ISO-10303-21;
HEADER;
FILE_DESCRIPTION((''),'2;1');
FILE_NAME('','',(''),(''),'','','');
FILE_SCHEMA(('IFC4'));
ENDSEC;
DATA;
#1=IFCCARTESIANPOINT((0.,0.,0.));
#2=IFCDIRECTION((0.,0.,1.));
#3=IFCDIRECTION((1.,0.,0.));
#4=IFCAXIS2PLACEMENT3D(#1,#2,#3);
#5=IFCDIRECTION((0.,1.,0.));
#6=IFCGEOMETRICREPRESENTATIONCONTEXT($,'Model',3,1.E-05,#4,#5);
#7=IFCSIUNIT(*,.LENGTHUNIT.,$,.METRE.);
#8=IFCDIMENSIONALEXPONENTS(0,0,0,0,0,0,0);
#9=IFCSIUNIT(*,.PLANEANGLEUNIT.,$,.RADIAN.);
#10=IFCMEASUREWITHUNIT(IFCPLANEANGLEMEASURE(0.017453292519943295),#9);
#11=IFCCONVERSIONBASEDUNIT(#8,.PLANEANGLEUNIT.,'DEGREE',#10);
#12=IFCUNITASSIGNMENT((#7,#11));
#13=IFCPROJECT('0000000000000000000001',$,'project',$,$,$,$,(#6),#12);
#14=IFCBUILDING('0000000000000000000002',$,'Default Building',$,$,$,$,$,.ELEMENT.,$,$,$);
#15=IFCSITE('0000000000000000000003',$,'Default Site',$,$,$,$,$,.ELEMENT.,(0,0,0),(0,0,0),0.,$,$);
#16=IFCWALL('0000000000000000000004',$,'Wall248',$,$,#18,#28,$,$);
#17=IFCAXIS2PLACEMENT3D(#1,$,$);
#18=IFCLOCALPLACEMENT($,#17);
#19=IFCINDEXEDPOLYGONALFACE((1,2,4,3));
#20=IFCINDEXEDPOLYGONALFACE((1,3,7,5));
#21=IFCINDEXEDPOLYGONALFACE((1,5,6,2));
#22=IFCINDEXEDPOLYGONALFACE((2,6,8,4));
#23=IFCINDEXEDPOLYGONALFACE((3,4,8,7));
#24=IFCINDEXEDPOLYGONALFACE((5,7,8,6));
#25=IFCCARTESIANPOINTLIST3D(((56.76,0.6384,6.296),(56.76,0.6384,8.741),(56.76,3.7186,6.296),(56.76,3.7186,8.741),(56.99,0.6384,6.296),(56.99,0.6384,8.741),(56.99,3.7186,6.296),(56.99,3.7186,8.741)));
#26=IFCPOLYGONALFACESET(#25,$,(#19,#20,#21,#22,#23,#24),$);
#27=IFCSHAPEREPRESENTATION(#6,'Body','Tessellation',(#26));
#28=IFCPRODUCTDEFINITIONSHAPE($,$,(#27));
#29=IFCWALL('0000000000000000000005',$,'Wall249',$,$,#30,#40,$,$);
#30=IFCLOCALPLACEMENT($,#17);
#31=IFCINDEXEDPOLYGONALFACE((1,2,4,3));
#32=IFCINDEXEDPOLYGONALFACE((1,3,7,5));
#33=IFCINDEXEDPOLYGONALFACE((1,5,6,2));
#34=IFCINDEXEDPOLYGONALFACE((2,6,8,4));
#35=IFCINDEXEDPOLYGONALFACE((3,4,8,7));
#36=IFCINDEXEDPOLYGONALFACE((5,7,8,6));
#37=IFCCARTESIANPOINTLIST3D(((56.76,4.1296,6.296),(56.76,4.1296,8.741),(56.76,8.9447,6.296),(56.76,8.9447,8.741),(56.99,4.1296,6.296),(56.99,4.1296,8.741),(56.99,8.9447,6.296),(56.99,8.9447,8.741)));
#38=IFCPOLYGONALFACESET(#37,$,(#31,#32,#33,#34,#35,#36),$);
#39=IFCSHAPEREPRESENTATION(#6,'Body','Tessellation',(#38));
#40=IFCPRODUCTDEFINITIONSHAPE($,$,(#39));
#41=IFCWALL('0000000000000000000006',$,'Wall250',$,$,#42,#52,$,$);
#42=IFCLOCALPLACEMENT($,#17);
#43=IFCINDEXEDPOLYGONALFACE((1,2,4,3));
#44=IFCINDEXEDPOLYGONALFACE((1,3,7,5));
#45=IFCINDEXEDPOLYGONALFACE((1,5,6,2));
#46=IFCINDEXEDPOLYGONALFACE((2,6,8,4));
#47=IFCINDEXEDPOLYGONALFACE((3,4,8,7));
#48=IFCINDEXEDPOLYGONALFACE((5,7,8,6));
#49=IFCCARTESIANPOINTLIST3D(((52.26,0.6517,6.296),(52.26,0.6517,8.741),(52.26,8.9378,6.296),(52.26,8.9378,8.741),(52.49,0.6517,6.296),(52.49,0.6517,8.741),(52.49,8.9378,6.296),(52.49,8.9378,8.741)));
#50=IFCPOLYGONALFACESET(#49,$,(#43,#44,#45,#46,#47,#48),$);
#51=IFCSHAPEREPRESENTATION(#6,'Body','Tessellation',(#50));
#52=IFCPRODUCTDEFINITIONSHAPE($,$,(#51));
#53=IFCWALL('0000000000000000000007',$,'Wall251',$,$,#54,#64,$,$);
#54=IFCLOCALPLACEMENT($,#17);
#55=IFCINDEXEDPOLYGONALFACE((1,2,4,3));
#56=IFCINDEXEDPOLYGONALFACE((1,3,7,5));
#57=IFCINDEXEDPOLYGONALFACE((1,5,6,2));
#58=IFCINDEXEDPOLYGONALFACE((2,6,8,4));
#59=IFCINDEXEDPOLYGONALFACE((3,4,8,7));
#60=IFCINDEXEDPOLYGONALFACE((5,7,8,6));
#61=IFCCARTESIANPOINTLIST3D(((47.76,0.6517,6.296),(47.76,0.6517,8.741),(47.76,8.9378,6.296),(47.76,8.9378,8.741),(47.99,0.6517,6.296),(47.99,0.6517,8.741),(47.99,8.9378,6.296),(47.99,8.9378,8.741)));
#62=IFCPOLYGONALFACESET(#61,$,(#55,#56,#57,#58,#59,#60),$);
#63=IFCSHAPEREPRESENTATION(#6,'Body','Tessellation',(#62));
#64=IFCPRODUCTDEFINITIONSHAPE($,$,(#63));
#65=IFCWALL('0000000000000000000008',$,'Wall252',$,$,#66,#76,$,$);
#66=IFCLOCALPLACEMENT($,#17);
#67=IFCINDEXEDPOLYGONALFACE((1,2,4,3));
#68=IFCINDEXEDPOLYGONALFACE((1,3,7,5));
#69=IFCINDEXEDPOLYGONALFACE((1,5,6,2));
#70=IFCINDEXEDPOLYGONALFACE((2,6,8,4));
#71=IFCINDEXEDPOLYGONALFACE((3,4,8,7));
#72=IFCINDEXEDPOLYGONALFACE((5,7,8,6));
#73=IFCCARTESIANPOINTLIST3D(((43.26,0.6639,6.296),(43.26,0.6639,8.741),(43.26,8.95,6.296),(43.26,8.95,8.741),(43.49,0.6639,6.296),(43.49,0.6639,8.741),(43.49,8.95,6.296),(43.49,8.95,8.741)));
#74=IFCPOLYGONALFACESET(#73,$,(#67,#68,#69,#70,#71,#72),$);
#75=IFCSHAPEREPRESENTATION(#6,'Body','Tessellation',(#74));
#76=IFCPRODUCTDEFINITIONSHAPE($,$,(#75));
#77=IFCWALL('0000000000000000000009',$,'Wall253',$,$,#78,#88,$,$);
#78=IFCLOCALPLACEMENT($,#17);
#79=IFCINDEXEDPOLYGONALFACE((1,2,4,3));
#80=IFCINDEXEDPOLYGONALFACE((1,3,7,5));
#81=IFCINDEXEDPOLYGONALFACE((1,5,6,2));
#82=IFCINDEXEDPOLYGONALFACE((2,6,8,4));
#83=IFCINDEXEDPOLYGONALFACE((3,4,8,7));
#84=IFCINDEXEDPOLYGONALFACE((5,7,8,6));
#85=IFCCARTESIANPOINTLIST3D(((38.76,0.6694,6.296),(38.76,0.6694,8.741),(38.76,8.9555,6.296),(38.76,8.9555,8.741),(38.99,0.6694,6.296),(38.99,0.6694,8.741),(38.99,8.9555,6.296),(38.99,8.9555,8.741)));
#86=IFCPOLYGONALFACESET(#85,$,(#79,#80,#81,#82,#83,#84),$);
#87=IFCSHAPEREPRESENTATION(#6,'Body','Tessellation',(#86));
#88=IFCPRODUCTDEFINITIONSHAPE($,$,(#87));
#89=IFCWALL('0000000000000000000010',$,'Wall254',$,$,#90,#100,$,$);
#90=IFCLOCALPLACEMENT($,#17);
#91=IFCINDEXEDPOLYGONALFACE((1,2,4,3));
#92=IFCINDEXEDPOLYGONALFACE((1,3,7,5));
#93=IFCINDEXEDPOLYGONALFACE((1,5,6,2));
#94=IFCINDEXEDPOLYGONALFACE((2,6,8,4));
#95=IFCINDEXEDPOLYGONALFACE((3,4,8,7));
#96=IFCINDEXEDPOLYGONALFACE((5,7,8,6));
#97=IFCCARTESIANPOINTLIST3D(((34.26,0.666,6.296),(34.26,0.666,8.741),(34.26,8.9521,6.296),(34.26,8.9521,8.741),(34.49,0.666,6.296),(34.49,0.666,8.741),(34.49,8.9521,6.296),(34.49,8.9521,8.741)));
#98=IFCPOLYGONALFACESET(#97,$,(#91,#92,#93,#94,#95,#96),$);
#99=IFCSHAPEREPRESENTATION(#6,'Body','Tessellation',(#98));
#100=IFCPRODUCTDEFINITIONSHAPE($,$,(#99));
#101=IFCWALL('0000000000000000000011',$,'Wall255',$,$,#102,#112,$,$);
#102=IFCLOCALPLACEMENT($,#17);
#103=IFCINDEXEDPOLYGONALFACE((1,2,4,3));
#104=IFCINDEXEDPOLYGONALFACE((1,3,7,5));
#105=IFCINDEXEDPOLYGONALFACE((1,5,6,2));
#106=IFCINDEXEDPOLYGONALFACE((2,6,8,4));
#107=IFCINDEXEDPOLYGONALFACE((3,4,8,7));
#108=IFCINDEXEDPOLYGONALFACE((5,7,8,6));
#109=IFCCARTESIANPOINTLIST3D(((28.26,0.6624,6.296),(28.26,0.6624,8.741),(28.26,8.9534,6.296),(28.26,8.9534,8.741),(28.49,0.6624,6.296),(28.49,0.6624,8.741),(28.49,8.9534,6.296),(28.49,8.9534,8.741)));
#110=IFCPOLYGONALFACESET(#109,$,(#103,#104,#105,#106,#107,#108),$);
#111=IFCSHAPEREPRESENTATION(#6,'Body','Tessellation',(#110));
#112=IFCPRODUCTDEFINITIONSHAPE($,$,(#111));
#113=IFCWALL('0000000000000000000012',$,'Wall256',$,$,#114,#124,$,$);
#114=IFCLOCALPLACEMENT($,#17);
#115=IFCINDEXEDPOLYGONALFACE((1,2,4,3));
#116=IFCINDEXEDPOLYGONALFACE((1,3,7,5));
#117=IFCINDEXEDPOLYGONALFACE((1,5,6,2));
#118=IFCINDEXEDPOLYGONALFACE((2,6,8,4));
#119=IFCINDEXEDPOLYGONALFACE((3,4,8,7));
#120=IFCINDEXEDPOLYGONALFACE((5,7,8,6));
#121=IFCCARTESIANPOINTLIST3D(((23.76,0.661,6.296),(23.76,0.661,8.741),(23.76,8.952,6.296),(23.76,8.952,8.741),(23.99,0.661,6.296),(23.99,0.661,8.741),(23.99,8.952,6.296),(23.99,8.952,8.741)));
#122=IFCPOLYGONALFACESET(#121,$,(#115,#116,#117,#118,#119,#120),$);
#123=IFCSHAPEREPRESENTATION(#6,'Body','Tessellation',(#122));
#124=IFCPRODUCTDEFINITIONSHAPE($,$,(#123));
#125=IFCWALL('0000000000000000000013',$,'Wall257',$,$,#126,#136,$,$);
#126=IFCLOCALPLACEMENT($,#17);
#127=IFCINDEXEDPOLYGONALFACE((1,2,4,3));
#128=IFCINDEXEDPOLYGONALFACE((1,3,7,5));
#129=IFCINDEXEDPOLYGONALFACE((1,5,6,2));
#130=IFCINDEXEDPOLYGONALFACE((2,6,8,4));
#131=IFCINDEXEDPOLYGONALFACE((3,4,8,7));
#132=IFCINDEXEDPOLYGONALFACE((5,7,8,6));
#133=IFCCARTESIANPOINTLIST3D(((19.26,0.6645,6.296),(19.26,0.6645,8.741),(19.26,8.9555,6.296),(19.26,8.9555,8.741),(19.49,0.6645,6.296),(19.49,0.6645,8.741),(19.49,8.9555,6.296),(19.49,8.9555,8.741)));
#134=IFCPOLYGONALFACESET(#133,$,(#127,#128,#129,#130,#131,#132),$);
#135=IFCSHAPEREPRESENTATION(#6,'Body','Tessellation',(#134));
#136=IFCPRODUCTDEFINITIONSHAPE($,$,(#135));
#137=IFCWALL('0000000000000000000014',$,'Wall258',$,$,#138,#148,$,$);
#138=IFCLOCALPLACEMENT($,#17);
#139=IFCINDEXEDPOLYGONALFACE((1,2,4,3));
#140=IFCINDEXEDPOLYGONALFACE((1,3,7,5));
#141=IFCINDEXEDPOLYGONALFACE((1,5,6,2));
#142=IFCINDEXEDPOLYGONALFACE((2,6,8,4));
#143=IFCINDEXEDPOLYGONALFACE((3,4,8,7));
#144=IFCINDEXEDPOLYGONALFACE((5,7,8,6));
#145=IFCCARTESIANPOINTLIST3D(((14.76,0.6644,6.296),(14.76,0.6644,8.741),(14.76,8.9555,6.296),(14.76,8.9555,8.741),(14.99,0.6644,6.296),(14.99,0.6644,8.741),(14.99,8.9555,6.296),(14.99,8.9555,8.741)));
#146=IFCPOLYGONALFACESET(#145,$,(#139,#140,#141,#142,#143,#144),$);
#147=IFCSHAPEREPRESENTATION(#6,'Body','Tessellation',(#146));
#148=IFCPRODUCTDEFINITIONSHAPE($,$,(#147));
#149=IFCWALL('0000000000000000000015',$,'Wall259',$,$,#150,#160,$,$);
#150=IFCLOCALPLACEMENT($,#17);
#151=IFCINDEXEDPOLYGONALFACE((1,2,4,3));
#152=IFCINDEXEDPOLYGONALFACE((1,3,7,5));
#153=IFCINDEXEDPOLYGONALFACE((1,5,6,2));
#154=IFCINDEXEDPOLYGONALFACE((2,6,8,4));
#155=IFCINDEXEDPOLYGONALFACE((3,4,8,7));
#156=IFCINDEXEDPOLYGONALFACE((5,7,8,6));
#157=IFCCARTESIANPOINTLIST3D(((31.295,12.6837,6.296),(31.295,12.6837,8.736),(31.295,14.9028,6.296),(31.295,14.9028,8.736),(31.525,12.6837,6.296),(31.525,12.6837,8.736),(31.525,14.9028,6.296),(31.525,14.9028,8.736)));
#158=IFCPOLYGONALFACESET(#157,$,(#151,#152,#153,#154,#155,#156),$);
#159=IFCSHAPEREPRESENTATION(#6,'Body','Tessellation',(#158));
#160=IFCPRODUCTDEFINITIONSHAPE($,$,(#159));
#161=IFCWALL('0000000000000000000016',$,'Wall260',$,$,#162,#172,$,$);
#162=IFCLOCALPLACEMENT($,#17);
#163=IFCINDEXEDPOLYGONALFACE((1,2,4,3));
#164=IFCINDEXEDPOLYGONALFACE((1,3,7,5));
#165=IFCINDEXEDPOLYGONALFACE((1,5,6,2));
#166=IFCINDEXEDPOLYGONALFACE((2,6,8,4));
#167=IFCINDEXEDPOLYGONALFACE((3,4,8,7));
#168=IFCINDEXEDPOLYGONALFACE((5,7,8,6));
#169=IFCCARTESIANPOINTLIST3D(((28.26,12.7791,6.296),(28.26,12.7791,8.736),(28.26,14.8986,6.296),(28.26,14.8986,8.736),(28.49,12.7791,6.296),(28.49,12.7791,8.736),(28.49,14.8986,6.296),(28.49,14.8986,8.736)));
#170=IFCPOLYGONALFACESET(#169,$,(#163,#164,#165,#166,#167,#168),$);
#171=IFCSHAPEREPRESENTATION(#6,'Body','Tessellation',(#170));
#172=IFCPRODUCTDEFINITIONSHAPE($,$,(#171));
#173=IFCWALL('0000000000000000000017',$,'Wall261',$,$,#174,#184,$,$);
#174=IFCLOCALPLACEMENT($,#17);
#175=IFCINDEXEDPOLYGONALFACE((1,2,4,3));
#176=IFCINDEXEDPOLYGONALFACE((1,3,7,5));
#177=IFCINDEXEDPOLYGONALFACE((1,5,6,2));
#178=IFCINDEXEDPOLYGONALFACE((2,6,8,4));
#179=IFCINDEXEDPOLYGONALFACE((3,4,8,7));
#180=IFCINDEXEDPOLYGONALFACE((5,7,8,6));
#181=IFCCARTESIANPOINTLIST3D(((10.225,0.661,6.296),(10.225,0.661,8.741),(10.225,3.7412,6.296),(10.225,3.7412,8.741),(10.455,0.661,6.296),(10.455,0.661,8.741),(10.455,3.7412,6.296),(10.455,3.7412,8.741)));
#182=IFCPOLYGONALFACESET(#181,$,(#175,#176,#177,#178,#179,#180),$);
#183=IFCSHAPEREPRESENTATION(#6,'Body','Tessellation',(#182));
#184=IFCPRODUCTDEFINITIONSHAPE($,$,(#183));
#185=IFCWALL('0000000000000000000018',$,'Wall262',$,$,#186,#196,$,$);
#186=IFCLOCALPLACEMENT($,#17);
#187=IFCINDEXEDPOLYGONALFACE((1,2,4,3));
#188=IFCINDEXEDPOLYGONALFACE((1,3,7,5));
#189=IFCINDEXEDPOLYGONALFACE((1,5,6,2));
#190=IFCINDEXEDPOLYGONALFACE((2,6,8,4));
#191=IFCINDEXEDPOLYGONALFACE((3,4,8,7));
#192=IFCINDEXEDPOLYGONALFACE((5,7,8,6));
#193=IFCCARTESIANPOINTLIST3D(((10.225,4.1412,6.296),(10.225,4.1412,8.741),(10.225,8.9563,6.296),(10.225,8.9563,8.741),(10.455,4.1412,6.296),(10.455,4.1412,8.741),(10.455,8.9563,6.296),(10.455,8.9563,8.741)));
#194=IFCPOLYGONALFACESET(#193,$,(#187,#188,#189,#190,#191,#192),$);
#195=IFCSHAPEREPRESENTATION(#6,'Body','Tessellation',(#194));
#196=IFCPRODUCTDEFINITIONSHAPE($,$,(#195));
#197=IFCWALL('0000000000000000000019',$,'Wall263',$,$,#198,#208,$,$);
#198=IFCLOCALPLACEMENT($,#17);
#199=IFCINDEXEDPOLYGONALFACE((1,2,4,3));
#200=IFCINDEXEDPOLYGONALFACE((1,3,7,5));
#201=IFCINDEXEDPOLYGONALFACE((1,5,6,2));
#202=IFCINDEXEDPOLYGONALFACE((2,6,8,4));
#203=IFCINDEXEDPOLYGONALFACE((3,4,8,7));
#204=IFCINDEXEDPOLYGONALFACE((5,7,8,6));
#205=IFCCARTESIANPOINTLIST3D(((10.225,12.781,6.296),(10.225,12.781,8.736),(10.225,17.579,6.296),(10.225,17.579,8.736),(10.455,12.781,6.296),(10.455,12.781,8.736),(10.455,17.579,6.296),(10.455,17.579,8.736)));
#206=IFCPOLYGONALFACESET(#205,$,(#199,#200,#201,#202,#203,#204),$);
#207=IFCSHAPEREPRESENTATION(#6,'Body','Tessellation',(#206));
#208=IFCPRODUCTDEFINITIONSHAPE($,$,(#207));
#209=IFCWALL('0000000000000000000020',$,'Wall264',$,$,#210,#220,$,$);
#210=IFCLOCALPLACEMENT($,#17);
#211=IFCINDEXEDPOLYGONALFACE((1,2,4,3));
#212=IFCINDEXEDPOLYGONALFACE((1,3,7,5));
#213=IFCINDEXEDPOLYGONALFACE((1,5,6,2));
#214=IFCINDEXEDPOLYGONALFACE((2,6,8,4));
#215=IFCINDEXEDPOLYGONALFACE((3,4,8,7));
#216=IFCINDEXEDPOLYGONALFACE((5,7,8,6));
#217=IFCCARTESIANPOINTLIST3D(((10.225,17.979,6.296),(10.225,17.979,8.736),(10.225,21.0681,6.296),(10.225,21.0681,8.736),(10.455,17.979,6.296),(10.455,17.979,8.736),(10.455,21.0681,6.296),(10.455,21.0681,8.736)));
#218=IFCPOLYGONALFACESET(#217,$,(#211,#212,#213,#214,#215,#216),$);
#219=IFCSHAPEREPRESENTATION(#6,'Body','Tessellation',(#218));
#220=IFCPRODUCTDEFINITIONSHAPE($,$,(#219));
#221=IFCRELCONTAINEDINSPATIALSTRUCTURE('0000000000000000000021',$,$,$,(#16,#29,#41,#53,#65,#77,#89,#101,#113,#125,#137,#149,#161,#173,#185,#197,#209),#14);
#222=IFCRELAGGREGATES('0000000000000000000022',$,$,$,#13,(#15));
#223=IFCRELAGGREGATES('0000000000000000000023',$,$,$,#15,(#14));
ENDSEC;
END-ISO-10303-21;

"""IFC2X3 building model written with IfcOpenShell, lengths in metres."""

from ifc_helpers import new_model, entity, si_unit, converted_unit, direction, frame, frame_2d, origin_with_axes, place, context, project, spatial, rectangle, extrude, element, save


model = new_model("IFC2X3")

# Units and contexts
model_context = context("Model", 3, precision=1e-05, world=origin_with_axes(), true_north=direction((0.0, 1.0, 0.0)))
ifc_project = project(units=[si_unit("LENGTHUNIT", "METRE"), converted_unit("PLANEANGLEUNIT", "DEGREE", entity("IfcPlaneAngleMeasure", 0.017453292519943295), si_unit("PLANEANGLEUNIT", "RADIAN"), dimensions=[0, 0, 0, 0, 0, 0, 0])], contexts=[model_context])

# Site, building
site = spatial("IfcSite", under=ifc_project, Name="Default Site", CompositionType="ELEMENT", RefLatitude=(0, 0, 0), RefLongitude=(0, 0, 0), RefElevation=0.0)
building = spatial("IfcBuilding", under=site, Name="Default Building", CompositionType="ELEMENT")

# Walls
placement = place(None, origin_with_axes())
element("IfcWall", 1, at=placement, inside=building, Name="Wall248", context=model_context, shape_type="SweptSolid", body=[
    extrude(rectangle(XDim=3.0802, YDim=0.23, at=frame_2d((0.0, 0.0), x_axis=(0.0, -1.0, 0.0))), frame((56.875, 2.1785, 6.296), z_axis=(0.0, 0.0, 1.0), x_axis=(1.0, 0.0, 0.0)), (0.0, 0.0, 1.0), 2.445),
])
element("IfcWall", 2, at=placement, inside=building, Name="Wall249", context=model_context, shape_type="SweptSolid", body=[
    extrude(rectangle(XDim=4.8151, YDim=0.23, at=frame_2d((0.0, 0.0), x_axis=(0.0, -1.0, 0.0))), frame((56.875, 6.5372, 6.296), z_axis=(0.0, 0.0, 1.0), x_axis=(1.0, 0.0, 0.0)), (0.0, 0.0, 1.0), 2.445),
])
element("IfcWall", 3, at=placement, inside=building, Name="Wall250", context=model_context, shape_type="SweptSolid", body=[
    extrude(rectangle(XDim=8.2861, YDim=0.23, at=frame_2d((0.0, 0.0), x_axis=(0.0, 1.0, 0.0))), frame((52.375, 4.7948, 6.296), z_axis=(0.0, 0.0, 1.0), x_axis=(1.0, 0.0, 0.0)), (0.0, 0.0, 1.0), 2.445),
])
element("IfcWall", 4, at=placement, inside=building, Name="Wall251", context=model_context, shape_type="SweptSolid", body=[
    extrude(rectangle(XDim=8.2861, YDim=0.23, at=frame_2d((0.0, 0.0), x_axis=(0.0, 1.0, 0.0))), frame((47.875, 4.7948, 6.296), z_axis=(0.0, 0.0, 1.0), x_axis=(1.0, 0.0, 0.0)), (0.0, 0.0, 1.0), 2.445),
])
element("IfcWall", 5, at=placement, inside=building, Name="Wall252", context=model_context, shape_type="SweptSolid", body=[
    extrude(rectangle(XDim=8.2861, YDim=0.23, at=frame_2d((0.0, 0.0), x_axis=(0.0, 1.0, 0.0))), frame((43.375, 4.8069, 6.296), z_axis=(0.0, 0.0, 1.0), x_axis=(1.0, 0.0, 0.0)), (0.0, 0.0, 1.0), 2.445),
])
element("IfcWall", 6, at=placement, inside=building, Name="Wall253", context=model_context, shape_type="SweptSolid", body=[
    extrude(rectangle(XDim=8.2861, YDim=0.23, at=frame_2d((0.0, 0.0), x_axis=(0.0, 1.0, 0.0))), frame((38.875, 4.8124, 6.296), z_axis=(0.0, 0.0, 1.0), x_axis=(1.0, 0.0, 0.0)), (0.0, 0.0, 1.0), 2.445),
])
element("IfcWall", 7, at=placement, inside=building, Name="Wall254", context=model_context, shape_type="SweptSolid", body=[
    extrude(rectangle(XDim=8.2861, YDim=0.23, at=frame_2d((0.0, 0.0), x_axis=(0.0, 1.0, 0.0))), frame((34.375, 4.8091, 6.296), z_axis=(0.0, 0.0, 1.0), x_axis=(1.0, 0.0, 0.0)), (0.0, 0.0, 1.0), 2.445),
])
element("IfcWall", 8, at=placement, inside=building, Name="Wall255", context=model_context, shape_type="SweptSolid", body=[
    extrude(rectangle(XDim=8.291, YDim=0.23, at=frame_2d((0.0, 0.0), x_axis=(0.0, 1.0, 0.0))), frame((28.375, 4.8079, 6.296), z_axis=(0.0, 0.0, 1.0), x_axis=(1.0, 0.0, 0.0)), (0.0, 0.0, 1.0), 2.445),
])
element("IfcWall", 9, at=placement, inside=building, Name="Wall256", context=model_context, shape_type="SweptSolid", body=[
    extrude(rectangle(XDim=8.291, YDim=0.23, at=frame_2d((0.0, 0.0), x_axis=(0.0, 1.0, 0.0))), frame((23.875, 4.8065, 6.296), z_axis=(0.0, 0.0, 1.0), x_axis=(1.0, 0.0, 0.0)), (0.0, 0.0, 1.0), 2.445),
])
element("IfcWall", 10, at=placement, inside=building, Name="Wall257", context=model_context, shape_type="SweptSolid", body=[
    extrude(rectangle(XDim=8.291, YDim=0.23, at=frame_2d((0.0, 0.0), x_axis=(0.0, 1.0, 0.0))), frame((19.375, 4.81, 6.296), z_axis=(0.0, 0.0, 1.0), x_axis=(1.0, 0.0, 0.0)), (0.0, 0.0, 1.0), 2.445),
])
element("IfcWall", 11, at=placement, inside=building, Name="Wall258", context=model_context, shape_type="SweptSolid", body=[
    extrude(rectangle(XDim=8.291, YDim=0.23, at=frame_2d((0.0, 0.0), x_axis=(0.0, 1.0, 0.0))), frame((14.875, 4.81, 6.296), z_axis=(0.0, 0.0, 1.0), x_axis=(1.0, 0.0, 0.0)), (0.0, 0.0, 1.0), 2.445),
])
element("IfcWall", 12, at=placement, inside=building, Name="Wall259", context=model_context, shape_type="SweptSolid", body=[
    extrude(rectangle(XDim=2.2191, YDim=0.23, at=frame_2d((0.0, 0.0), x_axis=(0.0, 1.0, 0.0))), frame((31.41, 13.7933, 6.296), z_axis=(0.0, 0.0, 1.0), x_axis=(1.0, 0.0, 0.0)), (0.0, 0.0, 1.0), 2.44),
])
element("IfcWall", 13, at=placement, inside=building, Name="Wall260", context=model_context, shape_type="SweptSolid", body=[
    extrude(rectangle(XDim=2.1195, YDim=0.23, at=frame_2d((0.0, 0.0), x_axis=(0.0, -1.0, 0.0))), frame((28.375, 13.8388, 6.296), z_axis=(0.0, 0.0, 1.0), x_axis=(1.0, 0.0, 0.0)), (0.0, 0.0, 1.0), 2.44),
])
element("IfcWall", 14, at=placement, inside=building, Name="Wall261", context=model_context, shape_type="SweptSolid", body=[
    extrude(rectangle(XDim=3.0802, YDim=0.23, at=frame_2d((0.0, 0.0), x_axis=(0.0, -1.0, 0.0))), frame((10.34, 2.2011, 6.296), z_axis=(0.0, 0.0, 1.0), x_axis=(1.0, 0.0, 0.0)), (0.0, 0.0, 1.0), 2.445),
])
element("IfcWall", 15, at=placement, inside=building, Name="Wall262", context=model_context, shape_type="SweptSolid", body=[
    extrude(rectangle(XDim=4.8151, YDim=0.23, at=frame_2d((0.0, 0.0), x_axis=(0.0, -1.0, 0.0))), frame((10.34, 6.5487, 6.296), z_axis=(0.0, 0.0, 1.0), x_axis=(1.0, 0.0, 0.0)), (0.0, 0.0, 1.0), 2.445),
])
element("IfcWall", 16, at=placement, inside=building, Name="Wall263", context=model_context, shape_type="SweptSolid", body=[
    extrude(rectangle(XDim=4.798, YDim=0.23, at=frame_2d((0.0, 0.0), x_axis=(0.0, -1.0, 0.0))), frame((10.34, 15.18, 6.296), z_axis=(0.0, 0.0, 1.0), x_axis=(1.0, 0.0, 0.0)), (0.0, 0.0, 1.0), 2.44),
])
element("IfcWall", 17, at=placement, inside=building, Name="Wall264", context=model_context, shape_type="SweptSolid", body=[
    extrude(rectangle(XDim=3.0891, YDim=0.23, at=frame_2d((0.0, 0.0), x_axis=(0.0, -1.0, 0.0))), frame((10.34, 19.5236, 6.296), z_axis=(0.0, 0.0, 1.0), x_axis=(1.0, 0.0, 0.0)), (0.0, 0.0, 1.0), 2.44),
])

save(model, "model.ifc")
